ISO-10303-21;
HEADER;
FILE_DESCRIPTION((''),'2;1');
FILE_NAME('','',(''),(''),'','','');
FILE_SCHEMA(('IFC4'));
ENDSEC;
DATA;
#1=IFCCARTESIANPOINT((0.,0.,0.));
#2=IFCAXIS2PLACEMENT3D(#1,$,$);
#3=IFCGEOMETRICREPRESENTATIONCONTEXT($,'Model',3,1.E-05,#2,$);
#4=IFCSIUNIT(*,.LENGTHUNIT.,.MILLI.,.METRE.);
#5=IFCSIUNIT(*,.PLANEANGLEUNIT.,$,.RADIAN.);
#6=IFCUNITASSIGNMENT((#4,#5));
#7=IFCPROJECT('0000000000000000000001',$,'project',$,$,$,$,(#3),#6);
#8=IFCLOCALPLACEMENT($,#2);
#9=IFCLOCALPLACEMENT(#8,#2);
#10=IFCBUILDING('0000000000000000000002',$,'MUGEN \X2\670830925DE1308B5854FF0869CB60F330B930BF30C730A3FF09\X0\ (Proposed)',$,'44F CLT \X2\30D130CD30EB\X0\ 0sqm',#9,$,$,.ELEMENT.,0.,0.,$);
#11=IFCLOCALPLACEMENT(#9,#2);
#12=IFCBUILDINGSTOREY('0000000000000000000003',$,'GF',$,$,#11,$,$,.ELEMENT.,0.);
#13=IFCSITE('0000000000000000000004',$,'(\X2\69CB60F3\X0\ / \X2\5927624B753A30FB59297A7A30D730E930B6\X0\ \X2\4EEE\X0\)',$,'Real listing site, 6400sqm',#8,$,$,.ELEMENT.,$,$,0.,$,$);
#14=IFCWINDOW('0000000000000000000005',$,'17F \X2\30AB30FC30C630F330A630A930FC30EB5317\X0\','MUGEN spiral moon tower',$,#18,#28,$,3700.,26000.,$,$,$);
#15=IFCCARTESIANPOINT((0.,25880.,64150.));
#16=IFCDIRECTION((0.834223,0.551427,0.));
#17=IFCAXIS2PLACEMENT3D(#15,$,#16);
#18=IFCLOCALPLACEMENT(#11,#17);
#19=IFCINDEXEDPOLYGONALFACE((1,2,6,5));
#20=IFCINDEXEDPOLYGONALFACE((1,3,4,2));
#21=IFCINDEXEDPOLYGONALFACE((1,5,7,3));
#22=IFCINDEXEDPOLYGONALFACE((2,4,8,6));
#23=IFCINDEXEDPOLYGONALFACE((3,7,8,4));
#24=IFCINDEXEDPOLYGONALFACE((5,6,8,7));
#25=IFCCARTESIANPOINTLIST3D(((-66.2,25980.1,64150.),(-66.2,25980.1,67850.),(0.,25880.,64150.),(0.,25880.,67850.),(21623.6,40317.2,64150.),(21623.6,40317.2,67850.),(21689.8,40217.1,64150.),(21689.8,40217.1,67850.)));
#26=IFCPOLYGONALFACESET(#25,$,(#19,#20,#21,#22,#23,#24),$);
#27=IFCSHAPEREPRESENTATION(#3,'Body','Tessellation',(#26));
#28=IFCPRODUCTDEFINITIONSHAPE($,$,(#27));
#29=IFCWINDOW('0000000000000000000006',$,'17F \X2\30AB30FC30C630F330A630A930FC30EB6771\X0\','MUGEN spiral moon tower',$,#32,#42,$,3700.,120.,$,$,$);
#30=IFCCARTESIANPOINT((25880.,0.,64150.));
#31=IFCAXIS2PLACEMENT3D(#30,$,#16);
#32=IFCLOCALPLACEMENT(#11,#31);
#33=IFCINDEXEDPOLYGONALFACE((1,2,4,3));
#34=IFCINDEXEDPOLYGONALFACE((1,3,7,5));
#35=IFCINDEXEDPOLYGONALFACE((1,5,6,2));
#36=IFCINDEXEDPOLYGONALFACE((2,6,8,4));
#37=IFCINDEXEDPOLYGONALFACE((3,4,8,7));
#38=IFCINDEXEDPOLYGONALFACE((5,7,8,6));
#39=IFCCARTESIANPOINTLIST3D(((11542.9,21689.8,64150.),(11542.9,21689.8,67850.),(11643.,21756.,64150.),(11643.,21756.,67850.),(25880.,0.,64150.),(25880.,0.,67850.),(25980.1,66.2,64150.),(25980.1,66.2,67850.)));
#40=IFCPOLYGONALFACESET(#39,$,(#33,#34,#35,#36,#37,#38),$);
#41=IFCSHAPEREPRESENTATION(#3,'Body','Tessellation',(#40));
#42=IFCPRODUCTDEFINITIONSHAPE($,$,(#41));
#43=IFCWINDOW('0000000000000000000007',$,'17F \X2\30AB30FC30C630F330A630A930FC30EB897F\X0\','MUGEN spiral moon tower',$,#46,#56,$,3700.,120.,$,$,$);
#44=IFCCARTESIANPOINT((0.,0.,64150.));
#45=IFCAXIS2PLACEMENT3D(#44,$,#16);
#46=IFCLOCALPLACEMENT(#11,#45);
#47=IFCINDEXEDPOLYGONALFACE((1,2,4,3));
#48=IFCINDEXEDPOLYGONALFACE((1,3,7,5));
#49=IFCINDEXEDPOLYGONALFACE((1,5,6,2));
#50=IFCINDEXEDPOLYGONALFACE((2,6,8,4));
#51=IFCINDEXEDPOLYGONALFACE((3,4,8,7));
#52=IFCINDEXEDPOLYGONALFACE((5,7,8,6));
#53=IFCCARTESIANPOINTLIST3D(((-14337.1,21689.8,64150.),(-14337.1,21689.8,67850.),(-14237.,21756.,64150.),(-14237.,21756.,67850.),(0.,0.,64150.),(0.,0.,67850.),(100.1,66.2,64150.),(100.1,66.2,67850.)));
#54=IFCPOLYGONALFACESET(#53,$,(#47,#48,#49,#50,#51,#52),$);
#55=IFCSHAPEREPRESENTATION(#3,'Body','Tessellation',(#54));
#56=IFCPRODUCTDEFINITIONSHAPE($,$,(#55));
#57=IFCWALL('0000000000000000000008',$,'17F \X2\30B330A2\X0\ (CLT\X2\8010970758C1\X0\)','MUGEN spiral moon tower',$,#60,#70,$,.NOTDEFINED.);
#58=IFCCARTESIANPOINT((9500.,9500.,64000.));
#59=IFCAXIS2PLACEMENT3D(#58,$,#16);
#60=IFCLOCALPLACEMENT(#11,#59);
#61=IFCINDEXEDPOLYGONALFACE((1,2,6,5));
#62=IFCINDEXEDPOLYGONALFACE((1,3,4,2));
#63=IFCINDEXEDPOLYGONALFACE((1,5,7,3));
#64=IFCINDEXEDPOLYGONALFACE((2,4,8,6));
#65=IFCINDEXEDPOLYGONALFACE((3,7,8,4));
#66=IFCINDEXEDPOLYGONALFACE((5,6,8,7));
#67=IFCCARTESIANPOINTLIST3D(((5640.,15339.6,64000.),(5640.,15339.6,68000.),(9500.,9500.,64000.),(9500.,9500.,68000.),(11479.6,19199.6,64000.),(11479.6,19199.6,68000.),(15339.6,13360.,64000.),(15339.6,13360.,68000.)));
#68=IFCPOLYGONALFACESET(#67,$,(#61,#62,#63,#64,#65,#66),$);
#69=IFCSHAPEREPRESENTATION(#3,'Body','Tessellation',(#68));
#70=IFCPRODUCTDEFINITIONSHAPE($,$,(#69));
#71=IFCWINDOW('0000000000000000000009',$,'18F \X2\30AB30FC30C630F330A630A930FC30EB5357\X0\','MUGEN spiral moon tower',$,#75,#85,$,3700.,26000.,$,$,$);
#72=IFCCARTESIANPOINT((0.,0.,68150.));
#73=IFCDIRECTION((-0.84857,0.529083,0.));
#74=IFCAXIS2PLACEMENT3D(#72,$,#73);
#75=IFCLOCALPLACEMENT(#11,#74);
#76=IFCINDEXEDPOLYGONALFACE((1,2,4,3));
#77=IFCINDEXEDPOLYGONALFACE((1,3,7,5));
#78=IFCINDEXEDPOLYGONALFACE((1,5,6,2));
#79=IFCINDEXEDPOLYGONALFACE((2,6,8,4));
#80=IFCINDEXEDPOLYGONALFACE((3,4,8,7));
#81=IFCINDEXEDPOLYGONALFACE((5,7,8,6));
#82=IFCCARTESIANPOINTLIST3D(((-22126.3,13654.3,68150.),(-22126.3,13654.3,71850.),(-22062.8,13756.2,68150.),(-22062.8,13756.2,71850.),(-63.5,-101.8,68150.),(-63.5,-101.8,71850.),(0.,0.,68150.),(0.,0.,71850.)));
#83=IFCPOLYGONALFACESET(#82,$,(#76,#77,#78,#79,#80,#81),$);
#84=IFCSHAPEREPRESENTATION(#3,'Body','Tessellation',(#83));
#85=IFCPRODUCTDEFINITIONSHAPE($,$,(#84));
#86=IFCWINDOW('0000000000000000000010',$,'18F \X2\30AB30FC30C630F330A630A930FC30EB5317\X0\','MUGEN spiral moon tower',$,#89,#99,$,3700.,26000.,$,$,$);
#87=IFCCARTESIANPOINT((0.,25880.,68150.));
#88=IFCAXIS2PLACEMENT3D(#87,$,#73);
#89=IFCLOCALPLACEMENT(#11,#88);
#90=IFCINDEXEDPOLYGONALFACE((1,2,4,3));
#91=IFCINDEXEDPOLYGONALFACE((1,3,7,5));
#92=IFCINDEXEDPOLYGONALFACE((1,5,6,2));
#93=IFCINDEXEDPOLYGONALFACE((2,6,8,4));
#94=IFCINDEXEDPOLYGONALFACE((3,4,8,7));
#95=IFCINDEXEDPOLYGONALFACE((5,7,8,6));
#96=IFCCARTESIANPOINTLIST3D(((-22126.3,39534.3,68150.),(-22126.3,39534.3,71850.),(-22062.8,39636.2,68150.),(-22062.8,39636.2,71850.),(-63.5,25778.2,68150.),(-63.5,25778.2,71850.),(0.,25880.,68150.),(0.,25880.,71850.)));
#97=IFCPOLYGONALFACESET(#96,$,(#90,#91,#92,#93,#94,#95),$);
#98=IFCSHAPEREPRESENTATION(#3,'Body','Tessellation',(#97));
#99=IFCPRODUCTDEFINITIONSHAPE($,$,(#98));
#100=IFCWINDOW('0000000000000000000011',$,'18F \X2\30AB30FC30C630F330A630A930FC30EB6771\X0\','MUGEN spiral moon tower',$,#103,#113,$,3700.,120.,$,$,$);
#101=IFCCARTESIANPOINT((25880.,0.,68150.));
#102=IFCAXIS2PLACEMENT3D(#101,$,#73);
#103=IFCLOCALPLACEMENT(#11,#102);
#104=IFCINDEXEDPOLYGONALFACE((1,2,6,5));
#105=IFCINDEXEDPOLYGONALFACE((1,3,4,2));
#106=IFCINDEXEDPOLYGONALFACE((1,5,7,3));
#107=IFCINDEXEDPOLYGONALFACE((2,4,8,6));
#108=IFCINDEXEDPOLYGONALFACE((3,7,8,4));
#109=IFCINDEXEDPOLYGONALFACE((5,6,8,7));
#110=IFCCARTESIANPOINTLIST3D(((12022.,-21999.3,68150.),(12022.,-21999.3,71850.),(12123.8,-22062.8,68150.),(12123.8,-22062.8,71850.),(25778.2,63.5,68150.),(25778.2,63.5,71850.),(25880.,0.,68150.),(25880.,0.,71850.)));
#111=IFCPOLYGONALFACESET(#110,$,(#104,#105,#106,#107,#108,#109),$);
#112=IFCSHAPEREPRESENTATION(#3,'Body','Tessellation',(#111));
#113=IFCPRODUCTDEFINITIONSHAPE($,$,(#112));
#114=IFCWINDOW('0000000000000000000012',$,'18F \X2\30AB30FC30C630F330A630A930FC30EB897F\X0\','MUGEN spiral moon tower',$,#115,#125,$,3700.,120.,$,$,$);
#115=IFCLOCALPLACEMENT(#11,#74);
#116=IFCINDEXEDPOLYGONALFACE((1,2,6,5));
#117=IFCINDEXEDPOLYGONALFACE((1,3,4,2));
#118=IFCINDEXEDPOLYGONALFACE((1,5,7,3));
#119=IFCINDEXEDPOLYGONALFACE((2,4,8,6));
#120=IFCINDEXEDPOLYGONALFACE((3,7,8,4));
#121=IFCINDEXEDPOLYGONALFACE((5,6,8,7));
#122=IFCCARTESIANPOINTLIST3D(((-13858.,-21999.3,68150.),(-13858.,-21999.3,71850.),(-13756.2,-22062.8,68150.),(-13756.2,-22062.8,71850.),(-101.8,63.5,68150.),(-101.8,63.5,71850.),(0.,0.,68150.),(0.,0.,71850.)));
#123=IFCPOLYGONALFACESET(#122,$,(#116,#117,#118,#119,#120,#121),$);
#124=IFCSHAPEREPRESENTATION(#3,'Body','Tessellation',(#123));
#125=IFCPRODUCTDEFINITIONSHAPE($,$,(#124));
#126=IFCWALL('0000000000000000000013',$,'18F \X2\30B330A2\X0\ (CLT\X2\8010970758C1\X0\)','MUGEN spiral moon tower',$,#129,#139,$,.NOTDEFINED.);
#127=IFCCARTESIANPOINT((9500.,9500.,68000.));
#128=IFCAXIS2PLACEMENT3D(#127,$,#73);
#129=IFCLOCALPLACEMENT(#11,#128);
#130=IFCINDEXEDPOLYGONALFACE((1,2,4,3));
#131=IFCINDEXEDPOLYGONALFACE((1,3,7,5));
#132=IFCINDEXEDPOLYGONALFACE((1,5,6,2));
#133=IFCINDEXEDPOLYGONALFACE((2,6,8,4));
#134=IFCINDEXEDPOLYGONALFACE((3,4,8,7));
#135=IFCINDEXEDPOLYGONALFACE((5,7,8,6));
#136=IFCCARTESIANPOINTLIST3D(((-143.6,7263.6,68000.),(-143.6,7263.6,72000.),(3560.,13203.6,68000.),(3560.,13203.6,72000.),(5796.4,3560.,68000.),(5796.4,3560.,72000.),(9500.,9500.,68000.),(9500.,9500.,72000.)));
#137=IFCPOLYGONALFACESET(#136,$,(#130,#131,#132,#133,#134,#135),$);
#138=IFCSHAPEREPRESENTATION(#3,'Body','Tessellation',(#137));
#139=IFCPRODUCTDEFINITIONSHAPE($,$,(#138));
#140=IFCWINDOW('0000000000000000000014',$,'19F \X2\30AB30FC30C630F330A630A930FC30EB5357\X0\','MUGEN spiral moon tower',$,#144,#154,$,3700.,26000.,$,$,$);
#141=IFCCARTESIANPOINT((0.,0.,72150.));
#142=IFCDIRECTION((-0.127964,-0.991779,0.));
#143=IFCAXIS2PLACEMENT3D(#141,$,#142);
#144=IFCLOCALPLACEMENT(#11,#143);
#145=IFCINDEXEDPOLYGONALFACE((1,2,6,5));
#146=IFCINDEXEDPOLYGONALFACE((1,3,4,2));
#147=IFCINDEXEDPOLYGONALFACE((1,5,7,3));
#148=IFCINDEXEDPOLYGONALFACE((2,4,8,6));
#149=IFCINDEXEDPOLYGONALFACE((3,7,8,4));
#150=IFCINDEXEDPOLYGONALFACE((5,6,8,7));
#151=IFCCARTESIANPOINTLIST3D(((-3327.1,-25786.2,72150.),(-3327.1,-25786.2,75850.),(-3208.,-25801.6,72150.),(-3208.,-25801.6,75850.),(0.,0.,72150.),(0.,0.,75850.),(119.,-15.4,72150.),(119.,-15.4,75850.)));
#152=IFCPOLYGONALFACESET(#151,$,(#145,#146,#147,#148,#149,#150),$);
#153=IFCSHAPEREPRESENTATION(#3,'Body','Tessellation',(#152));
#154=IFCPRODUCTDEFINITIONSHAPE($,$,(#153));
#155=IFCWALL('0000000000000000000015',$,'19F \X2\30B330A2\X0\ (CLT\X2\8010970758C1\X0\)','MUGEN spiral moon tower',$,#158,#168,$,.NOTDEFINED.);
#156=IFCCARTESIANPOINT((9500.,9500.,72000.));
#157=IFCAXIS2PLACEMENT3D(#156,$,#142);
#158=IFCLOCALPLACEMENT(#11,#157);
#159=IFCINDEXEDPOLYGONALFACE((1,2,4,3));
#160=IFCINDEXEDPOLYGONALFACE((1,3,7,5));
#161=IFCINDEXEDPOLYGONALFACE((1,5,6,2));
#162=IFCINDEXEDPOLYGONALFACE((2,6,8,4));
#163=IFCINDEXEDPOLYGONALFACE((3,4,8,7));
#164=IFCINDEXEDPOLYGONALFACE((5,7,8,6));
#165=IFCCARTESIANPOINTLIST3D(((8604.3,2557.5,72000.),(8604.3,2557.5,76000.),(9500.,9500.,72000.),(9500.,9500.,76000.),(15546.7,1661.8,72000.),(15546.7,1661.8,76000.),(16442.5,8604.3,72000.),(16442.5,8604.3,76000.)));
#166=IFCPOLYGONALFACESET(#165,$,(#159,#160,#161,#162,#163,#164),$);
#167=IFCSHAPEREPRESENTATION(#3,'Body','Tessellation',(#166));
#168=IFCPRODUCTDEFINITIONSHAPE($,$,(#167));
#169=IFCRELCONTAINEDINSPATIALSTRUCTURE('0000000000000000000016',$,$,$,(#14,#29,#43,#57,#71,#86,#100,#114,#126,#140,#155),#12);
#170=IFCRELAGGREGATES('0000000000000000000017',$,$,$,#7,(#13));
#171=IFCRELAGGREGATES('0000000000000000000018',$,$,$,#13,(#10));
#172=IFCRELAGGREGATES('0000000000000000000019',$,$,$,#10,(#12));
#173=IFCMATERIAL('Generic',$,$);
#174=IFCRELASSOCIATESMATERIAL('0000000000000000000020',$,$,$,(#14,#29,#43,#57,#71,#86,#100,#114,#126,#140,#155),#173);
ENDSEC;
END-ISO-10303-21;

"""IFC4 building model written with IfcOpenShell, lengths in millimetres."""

from ifc_helpers import new_model, si_unit, frame, frame_2d, origin, place, context, project, spatial, rectangle, extrude, material, element, save


model = new_model("IFC4")

# Units and contexts
model_context = context("Model", 3, precision=1e-05, world=origin())
ifc_project = project(units=[si_unit("LENGTHUNIT", "METRE", prefix="MILLI"), si_unit("PLANEANGLEUNIT", "RADIAN")], contexts=[model_context])

# Site, building, storey
site_placement = place(None, origin())
site = spatial("IfcSite", under=ifc_project, at=site_placement, Name="(構想 / 大手町・天空プラザ 仮)", ObjectType="Real listing site, 6400sqm", CompositionType="ELEMENT", RefElevation=0.0)
building_placement = place(site_placement, origin())
building = spatial("IfcBuilding", under=site, at=building_placement, Name="MUGEN 月を巡る塔（構想スタディ） (Proposed)", ObjectType="44F CLT パネル 0sqm", CompositionType="ELEMENT", ElevationOfRefHeight=0.0, ElevationOfTerrain=0.0)
storey_placement = place(building_placement, origin())
storey = spatial("IfcBuildingStorey", under=building, at=storey_placement, Name="GF", CompositionType="ELEMENT", Elevation=0.0)

# Shared definitions
ifc_material = material(Name="Generic")

# Windows
window_1_placement = place(storey_placement, frame((0.0, 25880.0, 64150.0), x_axis=(0.834223, 0.551427, 0.0)))
element("IfcWindow", 1, at=window_1_placement, inside=storey, material=ifc_material, Name="17F カーテンウォール北", Description="MUGEN spiral moon tower", OverallHeight=3700.0, OverallWidth=26000.0, context=model_context, shape_type="SweptSolid", body=[
    extrude(rectangle(XDim=26000.0, YDim=120.0, at=frame_2d((13000.0, 60.0))), frame((0.0, 25880.0, 64150.0), x_axis=(0.834223, 0.551427, 0.0)), (0.0, 0.0, 1.0), 3700.0),
])
window_2_placement = place(storey_placement, frame((25880.0, 0.0, 64150.0), x_axis=(0.834223, 0.551427, 0.0)))
element("IfcWindow", 2, at=window_2_placement, inside=storey, material=ifc_material, Name="17F カーテンウォール東", Description="MUGEN spiral moon tower", OverallHeight=3700.0, OverallWidth=120.0, context=model_context, shape_type="SweptSolid", body=[
    extrude(rectangle(XDim=120.0, YDim=26000.0, at=frame_2d((60.0, 13000.0))), frame((25880.0, 0.0, 64150.0), x_axis=(0.834223, 0.551427, 0.0)), (0.0, 0.0, 1.0), 3700.0),
])
window_3_placement = place(storey_placement, frame((0.0, 0.0, 64150.0), x_axis=(0.834223, 0.551427, 0.0)))
element("IfcWindow", 3, at=window_3_placement, inside=storey, material=ifc_material, Name="17F カーテンウォール西", Description="MUGEN spiral moon tower", OverallHeight=3700.0, OverallWidth=120.0, context=model_context, shape_type="SweptSolid", body=[
    extrude(rectangle(XDim=120.0, YDim=26000.0, at=frame_2d((60.0, 13000.0))), frame((0.0, 0.0, 64150.0), x_axis=(0.834223, 0.551427, 0.0)), (0.0, 0.0, 1.0), 3700.0),
])

# Wall
wall_1_placement = place(storey_placement, frame((9500.0, 9500.0, 64000.0), x_axis=(0.834223, 0.551427, 0.0)))
element("IfcWall", 4, at=wall_1_placement, inside=storey, material=ifc_material, Name="17F コア (CLT耐震壁)", Description="MUGEN spiral moon tower", PredefinedType="NOTDEFINED", context=model_context, shape_type="SweptSolid", body=[
    extrude(rectangle(XDim=7000.0, YDim=7000.0, at=frame_2d((3500.0, 3500.0))), frame((9500.0, 9500.0, 64000.0), x_axis=(0.834223, 0.551427, 0.0)), (0.0, 0.0, 1.0), 4000.0),
])

# Windows
window_4_placement = place(storey_placement, frame((0.0, 0.0, 68150.0), x_axis=(-0.84857, 0.529083, 0.0)))
element("IfcWindow", 5, at=window_4_placement, inside=storey, material=ifc_material, Name="18F カーテンウォール南", Description="MUGEN spiral moon tower", OverallHeight=3700.0, OverallWidth=26000.0, context=model_context, shape_type="SweptSolid", body=[
    extrude(rectangle(XDim=26000.0, YDim=120.0, at=frame_2d((13000.0, 60.0))), frame((0.0, 0.0, 68150.0), x_axis=(-0.84857, 0.529083, 0.0)), (0.0, 0.0, 1.0), 3700.0),
])
window_5_placement = place(storey_placement, frame((0.0, 25880.0, 68150.0), x_axis=(-0.84857, 0.529083, 0.0)))
element("IfcWindow", 6, at=window_5_placement, inside=storey, material=ifc_material, Name="18F カーテンウォール北", Description="MUGEN spiral moon tower", OverallHeight=3700.0, OverallWidth=26000.0, context=model_context, shape_type="SweptSolid", body=[
    extrude(rectangle(XDim=26000.0, YDim=120.0, at=frame_2d((13000.0, 60.0))), frame((0.0, 25880.0, 68150.0), x_axis=(-0.84857, 0.529083, 0.0)), (0.0, 0.0, 1.0), 3700.0),
])
window_6_placement = place(storey_placement, frame((25880.0, 0.0, 68150.0), x_axis=(-0.84857, 0.529083, 0.0)))
element("IfcWindow", 7, at=window_6_placement, inside=storey, material=ifc_material, Name="18F カーテンウォール東", Description="MUGEN spiral moon tower", OverallHeight=3700.0, OverallWidth=120.0, context=model_context, shape_type="SweptSolid", body=[
    extrude(rectangle(XDim=120.0, YDim=26000.0, at=frame_2d((60.0, 13000.0))), frame((25880.0, 0.0, 68150.0), x_axis=(-0.84857, 0.529083, 0.0)), (0.0, 0.0, 1.0), 3700.0),
])
window_7_placement = place(storey_placement, frame((0.0, 0.0, 68150.0), x_axis=(-0.84857, 0.529083, 0.0)))
element("IfcWindow", 8, at=window_7_placement, inside=storey, material=ifc_material, Name="18F カーテンウォール西", Description="MUGEN spiral moon tower", OverallHeight=3700.0, OverallWidth=120.0, context=model_context, shape_type="SweptSolid", body=[
    extrude(rectangle(XDim=120.0, YDim=26000.0, at=frame_2d((60.0, 13000.0))), frame((0.0, 0.0, 68150.0), x_axis=(-0.84857, 0.529083, 0.0)), (0.0, 0.0, 1.0), 3700.0),
])

# Wall
wall_2_placement = place(storey_placement, frame((9500.0, 9500.0, 68000.0), x_axis=(-0.84857, 0.529083, 0.0)))
element("IfcWall", 9, at=wall_2_placement, inside=storey, material=ifc_material, Name="18F コア (CLT耐震壁)", Description="MUGEN spiral moon tower", PredefinedType="NOTDEFINED", context=model_context, shape_type="SweptSolid", body=[
    extrude(rectangle(XDim=7000.0, YDim=7000.0, at=frame_2d((3500.0, 3500.0))), frame((9500.0, 9500.0, 68000.0), x_axis=(-0.84857, 0.529083, 0.0)), (0.0, 0.0, 1.0), 4000.0),
])

# Window
window_8_placement = place(storey_placement, frame((0.0, 0.0, 72150.0), x_axis=(-0.127964, -0.991779, 0.0)))
element("IfcWindow", 10, at=window_8_placement, inside=storey, material=ifc_material, Name="19F カーテンウォール南", Description="MUGEN spiral moon tower", OverallHeight=3700.0, OverallWidth=26000.0, context=model_context, shape_type="SweptSolid", body=[
    extrude(rectangle(XDim=26000.0, YDim=120.0, at=frame_2d((13000.0, 60.0))), frame((0.0, 0.0, 72150.0), x_axis=(-0.127964, -0.991779, 0.0)), (0.0, 0.0, 1.0), 3700.0),
])

# Wall
wall_3_placement = place(storey_placement, frame((9500.0, 9500.0, 72000.0), x_axis=(-0.127964, -0.991779, 0.0)))
element("IfcWall", 11, at=wall_3_placement, inside=storey, material=ifc_material, Name="19F コア (CLT耐震壁)", Description="MUGEN spiral moon tower", PredefinedType="NOTDEFINED", context=model_context, shape_type="SweptSolid", body=[
    extrude(rectangle(XDim=7000.0, YDim=7000.0, at=frame_2d((3500.0, 3500.0))), frame((9500.0, 9500.0, 72000.0), x_axis=(-0.127964, -0.991779, 0.0)), (0.0, 0.0, 1.0), 4000.0),
])

save(model, "model.ifc")
